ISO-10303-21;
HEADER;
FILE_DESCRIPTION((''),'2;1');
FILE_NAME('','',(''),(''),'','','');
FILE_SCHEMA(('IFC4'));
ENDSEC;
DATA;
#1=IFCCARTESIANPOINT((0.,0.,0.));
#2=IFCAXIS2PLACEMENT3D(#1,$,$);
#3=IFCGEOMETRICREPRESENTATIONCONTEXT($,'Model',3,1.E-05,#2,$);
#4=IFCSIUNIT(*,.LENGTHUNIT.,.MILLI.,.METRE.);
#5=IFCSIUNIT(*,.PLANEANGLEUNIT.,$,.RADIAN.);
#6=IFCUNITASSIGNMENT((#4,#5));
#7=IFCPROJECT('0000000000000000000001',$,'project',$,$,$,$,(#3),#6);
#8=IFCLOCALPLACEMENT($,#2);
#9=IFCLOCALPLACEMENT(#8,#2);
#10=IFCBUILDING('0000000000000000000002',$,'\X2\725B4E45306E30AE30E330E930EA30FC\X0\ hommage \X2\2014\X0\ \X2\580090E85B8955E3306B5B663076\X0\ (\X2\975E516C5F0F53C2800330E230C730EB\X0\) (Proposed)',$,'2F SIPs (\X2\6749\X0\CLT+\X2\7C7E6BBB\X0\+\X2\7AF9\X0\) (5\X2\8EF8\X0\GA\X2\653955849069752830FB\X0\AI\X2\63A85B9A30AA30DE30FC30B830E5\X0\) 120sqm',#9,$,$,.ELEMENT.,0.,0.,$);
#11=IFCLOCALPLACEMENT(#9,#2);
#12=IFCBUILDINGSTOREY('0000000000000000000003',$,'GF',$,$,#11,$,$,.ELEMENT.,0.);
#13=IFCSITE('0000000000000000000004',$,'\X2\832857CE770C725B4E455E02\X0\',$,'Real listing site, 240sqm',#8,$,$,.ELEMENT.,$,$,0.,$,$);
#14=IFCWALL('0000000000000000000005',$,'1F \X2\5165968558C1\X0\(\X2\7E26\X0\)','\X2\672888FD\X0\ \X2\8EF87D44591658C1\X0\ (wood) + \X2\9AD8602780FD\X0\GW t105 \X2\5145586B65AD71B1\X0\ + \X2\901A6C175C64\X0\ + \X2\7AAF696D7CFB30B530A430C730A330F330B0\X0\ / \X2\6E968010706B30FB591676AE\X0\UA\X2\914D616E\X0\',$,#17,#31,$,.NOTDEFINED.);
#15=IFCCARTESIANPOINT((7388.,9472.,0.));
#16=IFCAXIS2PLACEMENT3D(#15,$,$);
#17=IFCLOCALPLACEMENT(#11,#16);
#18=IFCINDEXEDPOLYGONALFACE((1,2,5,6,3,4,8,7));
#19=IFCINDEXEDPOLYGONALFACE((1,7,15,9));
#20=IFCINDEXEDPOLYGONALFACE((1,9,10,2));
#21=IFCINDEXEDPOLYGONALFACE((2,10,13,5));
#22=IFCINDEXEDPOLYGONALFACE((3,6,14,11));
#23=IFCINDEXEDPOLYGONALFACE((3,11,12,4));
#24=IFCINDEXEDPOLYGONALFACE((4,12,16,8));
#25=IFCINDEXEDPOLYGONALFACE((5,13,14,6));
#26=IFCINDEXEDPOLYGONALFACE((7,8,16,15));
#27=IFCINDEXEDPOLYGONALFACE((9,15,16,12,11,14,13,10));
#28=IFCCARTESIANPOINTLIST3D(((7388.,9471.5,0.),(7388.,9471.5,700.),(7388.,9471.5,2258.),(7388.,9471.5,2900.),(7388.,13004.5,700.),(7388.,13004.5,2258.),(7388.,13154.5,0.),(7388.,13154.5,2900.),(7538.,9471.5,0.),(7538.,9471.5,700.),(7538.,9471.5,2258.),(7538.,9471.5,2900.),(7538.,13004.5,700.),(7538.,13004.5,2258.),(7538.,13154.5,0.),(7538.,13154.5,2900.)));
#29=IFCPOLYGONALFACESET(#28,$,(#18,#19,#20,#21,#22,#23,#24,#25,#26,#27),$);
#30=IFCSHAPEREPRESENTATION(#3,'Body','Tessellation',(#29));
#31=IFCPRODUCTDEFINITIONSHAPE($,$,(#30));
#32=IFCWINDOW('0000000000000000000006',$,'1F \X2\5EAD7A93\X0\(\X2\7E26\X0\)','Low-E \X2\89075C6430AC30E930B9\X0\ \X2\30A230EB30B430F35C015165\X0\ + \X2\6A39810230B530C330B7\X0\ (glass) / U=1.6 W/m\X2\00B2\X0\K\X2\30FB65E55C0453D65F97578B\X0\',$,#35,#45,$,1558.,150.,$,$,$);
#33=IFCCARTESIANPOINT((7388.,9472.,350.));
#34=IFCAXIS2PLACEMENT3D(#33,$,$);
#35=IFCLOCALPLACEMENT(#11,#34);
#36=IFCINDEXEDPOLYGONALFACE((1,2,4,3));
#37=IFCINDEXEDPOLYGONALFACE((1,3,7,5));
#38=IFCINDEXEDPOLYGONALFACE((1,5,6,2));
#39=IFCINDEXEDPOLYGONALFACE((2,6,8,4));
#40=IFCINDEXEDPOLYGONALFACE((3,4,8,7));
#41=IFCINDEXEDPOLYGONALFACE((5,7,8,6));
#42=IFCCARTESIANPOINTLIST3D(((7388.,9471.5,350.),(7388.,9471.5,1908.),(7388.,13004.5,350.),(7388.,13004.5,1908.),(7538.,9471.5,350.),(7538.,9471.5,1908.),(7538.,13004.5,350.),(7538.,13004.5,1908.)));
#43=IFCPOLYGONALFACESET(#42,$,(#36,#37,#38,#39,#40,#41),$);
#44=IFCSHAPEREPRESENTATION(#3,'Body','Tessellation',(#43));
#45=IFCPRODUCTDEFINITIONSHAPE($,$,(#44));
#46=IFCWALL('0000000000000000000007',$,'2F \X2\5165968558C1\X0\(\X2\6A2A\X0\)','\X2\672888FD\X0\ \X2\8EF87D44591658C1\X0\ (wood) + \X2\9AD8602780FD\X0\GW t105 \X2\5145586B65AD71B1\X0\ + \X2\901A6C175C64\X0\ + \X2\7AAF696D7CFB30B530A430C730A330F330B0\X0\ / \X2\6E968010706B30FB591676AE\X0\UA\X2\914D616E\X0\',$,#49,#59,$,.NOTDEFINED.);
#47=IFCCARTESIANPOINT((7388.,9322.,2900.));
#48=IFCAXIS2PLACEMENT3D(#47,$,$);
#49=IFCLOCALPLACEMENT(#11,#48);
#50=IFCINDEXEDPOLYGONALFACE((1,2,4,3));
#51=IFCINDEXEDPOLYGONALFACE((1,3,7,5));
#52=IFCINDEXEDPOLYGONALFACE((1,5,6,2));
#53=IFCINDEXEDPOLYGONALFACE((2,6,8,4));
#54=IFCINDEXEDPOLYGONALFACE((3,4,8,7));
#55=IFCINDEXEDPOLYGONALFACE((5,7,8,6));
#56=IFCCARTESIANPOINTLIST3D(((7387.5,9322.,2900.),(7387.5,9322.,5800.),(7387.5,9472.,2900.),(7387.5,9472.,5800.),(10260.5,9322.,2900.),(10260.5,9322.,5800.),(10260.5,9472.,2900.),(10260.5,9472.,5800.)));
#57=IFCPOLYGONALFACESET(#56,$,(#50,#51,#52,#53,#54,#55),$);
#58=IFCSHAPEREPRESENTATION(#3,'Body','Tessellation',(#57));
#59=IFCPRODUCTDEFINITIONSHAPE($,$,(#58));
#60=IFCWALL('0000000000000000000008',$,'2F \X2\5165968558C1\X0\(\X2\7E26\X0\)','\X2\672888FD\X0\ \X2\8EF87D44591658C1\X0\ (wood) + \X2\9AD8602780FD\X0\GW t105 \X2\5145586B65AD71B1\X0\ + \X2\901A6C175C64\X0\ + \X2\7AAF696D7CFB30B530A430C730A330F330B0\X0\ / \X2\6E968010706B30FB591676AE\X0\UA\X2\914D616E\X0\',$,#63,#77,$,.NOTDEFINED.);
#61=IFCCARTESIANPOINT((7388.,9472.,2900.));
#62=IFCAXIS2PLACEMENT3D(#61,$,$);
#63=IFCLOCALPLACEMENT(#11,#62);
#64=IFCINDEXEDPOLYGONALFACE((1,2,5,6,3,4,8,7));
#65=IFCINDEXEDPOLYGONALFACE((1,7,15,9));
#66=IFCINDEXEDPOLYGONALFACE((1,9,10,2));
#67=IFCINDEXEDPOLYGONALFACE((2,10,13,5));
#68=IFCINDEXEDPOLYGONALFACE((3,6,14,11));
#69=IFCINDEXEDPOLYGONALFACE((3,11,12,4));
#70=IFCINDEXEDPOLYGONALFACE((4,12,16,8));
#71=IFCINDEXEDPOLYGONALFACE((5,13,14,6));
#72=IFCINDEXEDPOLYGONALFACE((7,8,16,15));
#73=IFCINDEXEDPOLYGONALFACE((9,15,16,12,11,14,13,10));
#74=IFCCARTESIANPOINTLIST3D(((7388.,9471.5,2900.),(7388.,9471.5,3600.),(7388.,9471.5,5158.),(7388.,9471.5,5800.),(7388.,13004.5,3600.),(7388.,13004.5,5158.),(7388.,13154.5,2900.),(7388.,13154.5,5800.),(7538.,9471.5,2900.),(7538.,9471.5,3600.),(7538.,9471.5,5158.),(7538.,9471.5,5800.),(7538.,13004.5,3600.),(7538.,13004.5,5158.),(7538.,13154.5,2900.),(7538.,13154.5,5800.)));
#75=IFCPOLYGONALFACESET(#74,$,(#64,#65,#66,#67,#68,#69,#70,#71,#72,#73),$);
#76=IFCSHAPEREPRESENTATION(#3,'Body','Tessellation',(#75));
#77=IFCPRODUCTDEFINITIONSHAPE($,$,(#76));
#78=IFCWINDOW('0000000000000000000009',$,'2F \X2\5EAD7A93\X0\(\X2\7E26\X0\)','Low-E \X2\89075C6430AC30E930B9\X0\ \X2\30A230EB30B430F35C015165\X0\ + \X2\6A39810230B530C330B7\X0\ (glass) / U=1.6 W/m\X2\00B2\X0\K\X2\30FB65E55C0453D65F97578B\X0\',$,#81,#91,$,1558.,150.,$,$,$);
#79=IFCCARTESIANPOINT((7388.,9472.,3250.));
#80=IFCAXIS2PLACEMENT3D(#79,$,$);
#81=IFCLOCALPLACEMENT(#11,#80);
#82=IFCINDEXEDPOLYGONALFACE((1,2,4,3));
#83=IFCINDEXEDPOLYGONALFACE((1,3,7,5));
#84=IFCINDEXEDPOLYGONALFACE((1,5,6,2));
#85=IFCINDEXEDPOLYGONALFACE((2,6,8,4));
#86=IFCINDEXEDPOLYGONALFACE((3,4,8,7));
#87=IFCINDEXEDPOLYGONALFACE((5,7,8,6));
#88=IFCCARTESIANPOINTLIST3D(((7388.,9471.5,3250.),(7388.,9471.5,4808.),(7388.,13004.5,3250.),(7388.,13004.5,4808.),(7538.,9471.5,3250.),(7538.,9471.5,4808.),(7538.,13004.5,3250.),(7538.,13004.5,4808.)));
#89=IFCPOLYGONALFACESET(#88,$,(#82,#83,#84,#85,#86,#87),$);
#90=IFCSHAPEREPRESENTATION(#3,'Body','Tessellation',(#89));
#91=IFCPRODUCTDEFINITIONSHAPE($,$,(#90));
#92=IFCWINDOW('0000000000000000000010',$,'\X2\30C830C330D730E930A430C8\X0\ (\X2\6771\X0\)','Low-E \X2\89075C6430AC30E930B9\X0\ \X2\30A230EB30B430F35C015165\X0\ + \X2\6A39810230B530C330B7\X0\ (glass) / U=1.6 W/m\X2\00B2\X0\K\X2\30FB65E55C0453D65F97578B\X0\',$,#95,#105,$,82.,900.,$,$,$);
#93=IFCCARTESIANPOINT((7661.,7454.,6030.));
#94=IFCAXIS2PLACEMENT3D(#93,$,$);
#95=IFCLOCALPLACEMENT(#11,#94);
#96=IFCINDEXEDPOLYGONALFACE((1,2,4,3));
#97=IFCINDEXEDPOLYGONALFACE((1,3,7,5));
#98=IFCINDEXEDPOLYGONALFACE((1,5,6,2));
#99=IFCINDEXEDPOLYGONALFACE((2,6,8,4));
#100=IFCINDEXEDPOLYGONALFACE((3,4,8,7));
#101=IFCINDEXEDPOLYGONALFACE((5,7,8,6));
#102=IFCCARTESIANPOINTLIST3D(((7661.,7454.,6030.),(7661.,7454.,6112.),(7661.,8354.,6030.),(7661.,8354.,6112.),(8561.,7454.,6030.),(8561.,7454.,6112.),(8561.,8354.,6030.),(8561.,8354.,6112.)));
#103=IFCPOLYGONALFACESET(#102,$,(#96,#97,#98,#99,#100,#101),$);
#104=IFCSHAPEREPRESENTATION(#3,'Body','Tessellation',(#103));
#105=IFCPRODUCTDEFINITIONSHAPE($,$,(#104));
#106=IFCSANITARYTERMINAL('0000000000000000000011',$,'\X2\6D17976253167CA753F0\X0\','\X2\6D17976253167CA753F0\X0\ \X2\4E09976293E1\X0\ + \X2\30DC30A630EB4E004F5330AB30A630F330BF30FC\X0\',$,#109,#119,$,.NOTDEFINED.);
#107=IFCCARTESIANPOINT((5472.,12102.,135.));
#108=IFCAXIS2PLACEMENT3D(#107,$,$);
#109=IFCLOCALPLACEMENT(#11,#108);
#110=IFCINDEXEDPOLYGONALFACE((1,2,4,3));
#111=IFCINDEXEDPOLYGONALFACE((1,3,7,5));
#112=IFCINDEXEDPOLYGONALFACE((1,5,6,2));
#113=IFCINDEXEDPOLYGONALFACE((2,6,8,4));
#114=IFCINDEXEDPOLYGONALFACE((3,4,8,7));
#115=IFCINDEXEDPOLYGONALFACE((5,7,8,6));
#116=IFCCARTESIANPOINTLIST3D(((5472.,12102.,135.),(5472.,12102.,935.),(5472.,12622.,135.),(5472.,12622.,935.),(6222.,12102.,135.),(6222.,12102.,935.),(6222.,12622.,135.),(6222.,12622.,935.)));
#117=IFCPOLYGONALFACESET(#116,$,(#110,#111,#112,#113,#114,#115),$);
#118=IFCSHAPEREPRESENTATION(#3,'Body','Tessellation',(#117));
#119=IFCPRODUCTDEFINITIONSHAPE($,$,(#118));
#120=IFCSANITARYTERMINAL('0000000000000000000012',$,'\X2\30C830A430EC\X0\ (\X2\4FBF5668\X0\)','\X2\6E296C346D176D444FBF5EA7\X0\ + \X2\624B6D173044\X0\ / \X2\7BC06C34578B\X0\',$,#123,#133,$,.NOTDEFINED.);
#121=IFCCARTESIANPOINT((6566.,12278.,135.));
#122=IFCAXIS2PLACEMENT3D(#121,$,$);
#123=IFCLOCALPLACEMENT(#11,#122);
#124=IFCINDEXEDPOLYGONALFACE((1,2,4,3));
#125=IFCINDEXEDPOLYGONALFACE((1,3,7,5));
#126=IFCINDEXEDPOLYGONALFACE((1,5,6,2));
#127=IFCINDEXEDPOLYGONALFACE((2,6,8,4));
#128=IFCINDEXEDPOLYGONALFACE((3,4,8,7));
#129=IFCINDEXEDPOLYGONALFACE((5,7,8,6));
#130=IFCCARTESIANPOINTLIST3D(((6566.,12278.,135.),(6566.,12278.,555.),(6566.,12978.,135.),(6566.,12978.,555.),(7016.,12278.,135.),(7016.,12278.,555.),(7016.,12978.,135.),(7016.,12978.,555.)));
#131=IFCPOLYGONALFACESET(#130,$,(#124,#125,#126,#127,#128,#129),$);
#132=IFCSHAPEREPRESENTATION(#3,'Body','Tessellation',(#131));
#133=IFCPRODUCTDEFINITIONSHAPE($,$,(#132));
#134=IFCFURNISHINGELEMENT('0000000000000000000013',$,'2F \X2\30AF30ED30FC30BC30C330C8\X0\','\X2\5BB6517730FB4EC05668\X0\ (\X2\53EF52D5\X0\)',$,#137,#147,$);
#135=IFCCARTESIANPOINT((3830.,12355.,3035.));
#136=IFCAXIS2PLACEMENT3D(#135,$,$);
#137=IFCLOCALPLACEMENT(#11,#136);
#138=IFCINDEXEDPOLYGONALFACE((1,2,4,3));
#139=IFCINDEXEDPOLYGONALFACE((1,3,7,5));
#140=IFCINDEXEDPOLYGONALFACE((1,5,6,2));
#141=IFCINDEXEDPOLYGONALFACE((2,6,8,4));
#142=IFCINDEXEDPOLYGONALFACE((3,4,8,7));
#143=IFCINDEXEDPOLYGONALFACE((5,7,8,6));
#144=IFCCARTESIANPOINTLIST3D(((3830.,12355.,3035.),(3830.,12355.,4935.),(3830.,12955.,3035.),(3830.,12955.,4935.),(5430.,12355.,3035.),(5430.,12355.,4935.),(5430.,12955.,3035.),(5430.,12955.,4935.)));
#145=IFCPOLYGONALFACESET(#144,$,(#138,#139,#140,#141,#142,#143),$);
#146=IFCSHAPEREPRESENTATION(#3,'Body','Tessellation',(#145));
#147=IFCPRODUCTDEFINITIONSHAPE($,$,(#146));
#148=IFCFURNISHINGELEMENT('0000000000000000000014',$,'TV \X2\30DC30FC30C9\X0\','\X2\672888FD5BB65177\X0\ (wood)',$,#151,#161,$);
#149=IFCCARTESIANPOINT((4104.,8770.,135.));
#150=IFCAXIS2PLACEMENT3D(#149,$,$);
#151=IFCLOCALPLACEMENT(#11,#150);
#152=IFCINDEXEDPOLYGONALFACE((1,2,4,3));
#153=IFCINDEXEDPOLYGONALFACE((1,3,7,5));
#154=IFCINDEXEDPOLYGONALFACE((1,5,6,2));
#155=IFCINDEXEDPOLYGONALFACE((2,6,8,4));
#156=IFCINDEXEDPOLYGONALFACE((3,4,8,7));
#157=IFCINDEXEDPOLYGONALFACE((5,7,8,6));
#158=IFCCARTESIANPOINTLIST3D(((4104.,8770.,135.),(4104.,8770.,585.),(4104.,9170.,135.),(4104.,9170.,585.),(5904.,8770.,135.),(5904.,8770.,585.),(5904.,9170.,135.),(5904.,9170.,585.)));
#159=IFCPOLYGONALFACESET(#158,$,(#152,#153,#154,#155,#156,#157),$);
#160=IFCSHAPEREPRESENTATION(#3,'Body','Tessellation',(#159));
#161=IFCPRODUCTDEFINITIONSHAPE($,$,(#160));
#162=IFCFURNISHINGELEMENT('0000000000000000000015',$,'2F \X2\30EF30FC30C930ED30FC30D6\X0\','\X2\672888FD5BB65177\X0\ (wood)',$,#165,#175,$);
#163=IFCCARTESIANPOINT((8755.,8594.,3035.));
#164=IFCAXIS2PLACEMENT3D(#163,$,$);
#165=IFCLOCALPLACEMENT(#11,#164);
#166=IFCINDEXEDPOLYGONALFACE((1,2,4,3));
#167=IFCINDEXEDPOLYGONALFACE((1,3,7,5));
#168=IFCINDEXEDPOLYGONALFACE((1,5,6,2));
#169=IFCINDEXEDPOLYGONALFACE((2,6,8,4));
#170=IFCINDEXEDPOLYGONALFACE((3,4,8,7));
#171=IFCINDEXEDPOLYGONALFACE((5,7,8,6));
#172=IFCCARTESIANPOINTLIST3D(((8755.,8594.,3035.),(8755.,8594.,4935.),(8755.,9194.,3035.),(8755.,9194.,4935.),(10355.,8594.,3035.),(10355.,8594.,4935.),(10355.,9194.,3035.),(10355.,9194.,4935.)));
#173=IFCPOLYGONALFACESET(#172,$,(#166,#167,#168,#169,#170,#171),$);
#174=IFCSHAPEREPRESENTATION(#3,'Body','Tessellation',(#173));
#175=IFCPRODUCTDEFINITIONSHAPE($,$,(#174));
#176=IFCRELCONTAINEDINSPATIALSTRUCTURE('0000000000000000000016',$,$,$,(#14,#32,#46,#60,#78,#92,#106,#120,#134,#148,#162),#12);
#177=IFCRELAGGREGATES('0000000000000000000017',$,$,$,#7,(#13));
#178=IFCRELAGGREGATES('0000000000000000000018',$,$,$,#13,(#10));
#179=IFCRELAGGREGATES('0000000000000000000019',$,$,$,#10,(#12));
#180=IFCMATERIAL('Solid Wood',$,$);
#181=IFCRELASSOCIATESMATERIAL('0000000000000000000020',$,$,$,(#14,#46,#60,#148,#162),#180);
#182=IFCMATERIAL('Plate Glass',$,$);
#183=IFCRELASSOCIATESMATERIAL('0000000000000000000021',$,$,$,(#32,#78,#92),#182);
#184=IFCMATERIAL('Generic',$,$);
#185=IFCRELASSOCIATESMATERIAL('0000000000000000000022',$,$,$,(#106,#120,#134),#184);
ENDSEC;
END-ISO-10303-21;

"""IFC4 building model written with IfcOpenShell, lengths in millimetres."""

from ifc_helpers import new_model, si_unit, frame, frame_2d, origin, place, context, project, spatial, rectangle, extrude, material, element, fill, save


model = new_model("IFC4")

# Units and contexts
model_context = context("Model", 3, precision=1e-05, world=origin())
ifc_project = project(units=[si_unit("LENGTHUNIT", "METRE", prefix="MILLI"), si_unit("PLANEANGLEUNIT", "RADIAN")], contexts=[model_context])

# Site, building, storey
site_placement = place(None, origin())
site = spatial("IfcSite", under=ifc_project, at=site_placement, Name="茨城県牛久市", ObjectType="Real listing site, 240sqm", CompositionType="ELEMENT", RefElevation=0.0)
building_placement = place(site_placement, origin())
building = spatial("IfcBuilding", under=site, at=building_placement, Name="牛久のギャラリー hommage — 堀部安嗣に学ぶ (非公式参考モデル) (Proposed)", ObjectType="2F SIPs (杉CLT+籾殻+竹) (5軸GA改善適用・AI推定オマージュ) 120sqm", CompositionType="ELEMENT", ElevationOfRefHeight=0.0, ElevationOfTerrain=0.0)
storey_placement = place(building_placement, origin())
storey = spatial("IfcBuildingStorey", under=building, at=storey_placement, Name="GF", CompositionType="ELEMENT", Elevation=0.0)

# Shared definitions
ifc_material_1 = material(Name="Solid Wood")

# Wall, opening, window
wall_1_placement = place(storey_placement, frame((7388.0, 9472.0, 0.0)))
wall_1 = element("IfcWall", 1, at=wall_1_placement, inside=storey, material=ifc_material_1, Name="1F 入隅壁(縦)", Description="木製 軸組外壁 (wood) + 高性能GW t105 充填断熱 + 通気層 + 窯業系サイディング / 準耐火・外皮UA配慮", PredefinedType="NOTDEFINED", context=model_context, shape_type="SweptSolid", body=[
    extrude(rectangle(XDim=150.0, YDim=3683.0, at=frame_2d((75.0, 1841.0))), frame((7388.0, 9472.0, 0.0)), (0.0, 0.0, 1.0), 2900.0),
])
opening_1_placement = place(storey_placement, frame((7388.0, 9472.0, 350.0)))
opening_1 = element("IfcOpeningElement", 2, at=opening_1_placement, cuts=wall_1, PredefinedType="NOTDEFINED", context=model_context, shape_type="SweptSolid", body=[
    extrude(rectangle(XDim=150.0, YDim=3533.0, at=frame_2d((75.0, 1766.0))), frame((7388.0, 9472.0, 350.0)), (0.0, 0.0, 1.0), 1558.0),
])
ifc_material_2 = material(Name="Plate Glass")
window_1_placement = place(storey_placement, frame((7388.0, 9472.0, 350.0)))
window_1 = element("IfcWindow", 3, at=window_1_placement, inside=storey, material=ifc_material_2, Name="1F 庭窓(縦)", Description="Low-E 複層ガラス アルゴン封入 + 樹脂サッシ (glass) / U=1.6 W/m²K・日射取得型", OverallHeight=1558.0, OverallWidth=150.0, context=model_context, shape_type="SweptSolid", body=[
    extrude(rectangle(XDim=150.0, YDim=3533.0, at=frame_2d((75.0, 1766.0))), frame((7388.0, 9472.0, 350.0)), (0.0, 0.0, 1.0), 1558.0),
])
fill(opening_1, window_1)

# Wall
wall_2_placement = place(storey_placement, frame((7388.0, 9322.0, 2900.0)))
element("IfcWall", 4, at=wall_2_placement, inside=storey, material=ifc_material_1, Name="2F 入隅壁(横)", Description="木製 軸組外壁 (wood) + 高性能GW t105 充填断熱 + 通気層 + 窯業系サイディング / 準耐火・外皮UA配慮", PredefinedType="NOTDEFINED", context=model_context, shape_type="SweptSolid", body=[
    extrude(rectangle(XDim=2873.0, YDim=150.0, at=frame_2d((1436.0, 75.0))), frame((7388.0, 9322.0, 2900.0)), (0.0, 0.0, 1.0), 2900.0),
])

# Wall, opening, window
wall_3_placement = place(storey_placement, frame((7388.0, 9472.0, 2900.0)))
wall_3 = element("IfcWall", 5, at=wall_3_placement, inside=storey, material=ifc_material_1, Name="2F 入隅壁(縦)", Description="木製 軸組外壁 (wood) + 高性能GW t105 充填断熱 + 通気層 + 窯業系サイディング / 準耐火・外皮UA配慮", PredefinedType="NOTDEFINED", context=model_context, shape_type="SweptSolid", body=[
    extrude(rectangle(XDim=150.0, YDim=3683.0, at=frame_2d((75.0, 1841.0))), frame((7388.0, 9472.0, 2900.0)), (0.0, 0.0, 1.0), 2900.0),
])
opening_2_placement = place(storey_placement, frame((7388.0, 9472.0, 3250.0)))
opening_2 = element("IfcOpeningElement", 6, at=opening_2_placement, cuts=wall_3, PredefinedType="NOTDEFINED", context=model_context, shape_type="SweptSolid", body=[
    extrude(rectangle(XDim=150.0, YDim=3533.0, at=frame_2d((75.0, 1766.0))), frame((7388.0, 9472.0, 3250.0)), (0.0, 0.0, 1.0), 1558.0),
])
window_2_placement = place(storey_placement, frame((7388.0, 9472.0, 3250.0)))
window_2 = element("IfcWindow", 7, at=window_2_placement, inside=storey, material=ifc_material_2, Name="2F 庭窓(縦)", Description="Low-E 複層ガラス アルゴン封入 + 樹脂サッシ (glass) / U=1.6 W/m²K・日射取得型", OverallHeight=1558.0, OverallWidth=150.0, context=model_context, shape_type="SweptSolid", body=[
    extrude(rectangle(XDim=150.0, YDim=3533.0, at=frame_2d((75.0, 1766.0))), frame((7388.0, 9472.0, 3250.0)), (0.0, 0.0, 1.0), 1558.0),
])
fill(opening_2, window_2)

# Window
window_3_placement = place(storey_placement, frame((7661.0, 7454.0, 6030.0)))
element("IfcWindow", 8, at=window_3_placement, inside=storey, material=ifc_material_2, Name="トップライト (東)", Description="Low-E 複層ガラス アルゴン封入 + 樹脂サッシ (glass) / U=1.6 W/m²K・日射取得型", OverallHeight=82.0, OverallWidth=900.0, context=model_context, shape_type="SweptSolid", body=[
    extrude(rectangle(XDim=900.0, YDim=900.0, at=frame_2d((450.0, 450.0))), frame((7661.0, 7454.0, 6030.0)), (0.0, 0.0, 1.0), 82.0),
])

# Sanitary terminals
ifc_material_3 = material(Name="Generic")
sanitary_terminal_1_placement = place(storey_placement, frame((5472.0, 12102.0, 135.0)))
element("IfcSanitaryTerminal", 9, at=sanitary_terminal_1_placement, inside=storey, material=ifc_material_3, Name="洗面化粧台", Description="洗面化粧台 三面鏡 + ボウル一体カウンター", PredefinedType="NOTDEFINED", context=model_context, shape_type="SweptSolid", body=[
    extrude(rectangle(XDim=750.0, YDim=520.0, at=frame_2d((375.0, 260.0))), frame((5472.0, 12102.0, 135.0)), (0.0, 0.0, 1.0), 800.0),
])
sanitary_terminal_2_placement = place(storey_placement, frame((6566.0, 12278.0, 135.0)))
element("IfcSanitaryTerminal", 10, at=sanitary_terminal_2_placement, inside=storey, material=ifc_material_3, Name="トイレ (便器)", Description="温水洗浄便座 + 手洗い / 節水型", PredefinedType="NOTDEFINED", context=model_context, shape_type="SweptSolid", body=[
    extrude(rectangle(XDim=450.0, YDim=700.0, at=frame_2d((225.0, 350.0))), frame((6566.0, 12278.0, 135.0)), (0.0, 0.0, 1.0), 420.0),
])

# Furnishing elements
furnishing_1_placement = place(storey_placement, frame((3830.0, 12355.0, 3035.0)))
element("IfcFurnishingElement", 11, at=furnishing_1_placement, inside=storey, material=ifc_material_3, Name="2F クローゼット", Description="家具・什器 (可動)", context=model_context, shape_type="SweptSolid", body=[
    extrude(rectangle(XDim=1600.0, YDim=600.0, at=frame_2d((800.0, 300.0))), frame((3830.0, 12355.0, 3035.0)), (0.0, 0.0, 1.0), 1900.0),
])
furnishing_2_placement = place(storey_placement, frame((4104.0, 8770.0, 135.0)))
element("IfcFurnishingElement", 12, at=furnishing_2_placement, inside=storey, material=ifc_material_1, Name="TV ボード", Description="木製家具 (wood)", context=model_context, shape_type="SweptSolid", body=[
    extrude(rectangle(XDim=1800.0, YDim=400.0, at=frame_2d((900.0, 200.0))), frame((4104.0, 8770.0, 135.0)), (0.0, 0.0, 1.0), 450.0),
])
furnishing_3_placement = place(storey_placement, frame((8755.0, 8594.0, 3035.0)))
element("IfcFurnishingElement", 13, at=furnishing_3_placement, inside=storey, material=ifc_material_1, Name="2F ワードローブ", Description="木製家具 (wood)", context=model_context, shape_type="SweptSolid", body=[
    extrude(rectangle(XDim=1600.0, YDim=600.0, at=frame_2d((800.0, 300.0))), frame((8755.0, 8594.0, 3035.0)), (0.0, 0.0, 1.0), 1900.0),
])

save(model, "model.ifc")
